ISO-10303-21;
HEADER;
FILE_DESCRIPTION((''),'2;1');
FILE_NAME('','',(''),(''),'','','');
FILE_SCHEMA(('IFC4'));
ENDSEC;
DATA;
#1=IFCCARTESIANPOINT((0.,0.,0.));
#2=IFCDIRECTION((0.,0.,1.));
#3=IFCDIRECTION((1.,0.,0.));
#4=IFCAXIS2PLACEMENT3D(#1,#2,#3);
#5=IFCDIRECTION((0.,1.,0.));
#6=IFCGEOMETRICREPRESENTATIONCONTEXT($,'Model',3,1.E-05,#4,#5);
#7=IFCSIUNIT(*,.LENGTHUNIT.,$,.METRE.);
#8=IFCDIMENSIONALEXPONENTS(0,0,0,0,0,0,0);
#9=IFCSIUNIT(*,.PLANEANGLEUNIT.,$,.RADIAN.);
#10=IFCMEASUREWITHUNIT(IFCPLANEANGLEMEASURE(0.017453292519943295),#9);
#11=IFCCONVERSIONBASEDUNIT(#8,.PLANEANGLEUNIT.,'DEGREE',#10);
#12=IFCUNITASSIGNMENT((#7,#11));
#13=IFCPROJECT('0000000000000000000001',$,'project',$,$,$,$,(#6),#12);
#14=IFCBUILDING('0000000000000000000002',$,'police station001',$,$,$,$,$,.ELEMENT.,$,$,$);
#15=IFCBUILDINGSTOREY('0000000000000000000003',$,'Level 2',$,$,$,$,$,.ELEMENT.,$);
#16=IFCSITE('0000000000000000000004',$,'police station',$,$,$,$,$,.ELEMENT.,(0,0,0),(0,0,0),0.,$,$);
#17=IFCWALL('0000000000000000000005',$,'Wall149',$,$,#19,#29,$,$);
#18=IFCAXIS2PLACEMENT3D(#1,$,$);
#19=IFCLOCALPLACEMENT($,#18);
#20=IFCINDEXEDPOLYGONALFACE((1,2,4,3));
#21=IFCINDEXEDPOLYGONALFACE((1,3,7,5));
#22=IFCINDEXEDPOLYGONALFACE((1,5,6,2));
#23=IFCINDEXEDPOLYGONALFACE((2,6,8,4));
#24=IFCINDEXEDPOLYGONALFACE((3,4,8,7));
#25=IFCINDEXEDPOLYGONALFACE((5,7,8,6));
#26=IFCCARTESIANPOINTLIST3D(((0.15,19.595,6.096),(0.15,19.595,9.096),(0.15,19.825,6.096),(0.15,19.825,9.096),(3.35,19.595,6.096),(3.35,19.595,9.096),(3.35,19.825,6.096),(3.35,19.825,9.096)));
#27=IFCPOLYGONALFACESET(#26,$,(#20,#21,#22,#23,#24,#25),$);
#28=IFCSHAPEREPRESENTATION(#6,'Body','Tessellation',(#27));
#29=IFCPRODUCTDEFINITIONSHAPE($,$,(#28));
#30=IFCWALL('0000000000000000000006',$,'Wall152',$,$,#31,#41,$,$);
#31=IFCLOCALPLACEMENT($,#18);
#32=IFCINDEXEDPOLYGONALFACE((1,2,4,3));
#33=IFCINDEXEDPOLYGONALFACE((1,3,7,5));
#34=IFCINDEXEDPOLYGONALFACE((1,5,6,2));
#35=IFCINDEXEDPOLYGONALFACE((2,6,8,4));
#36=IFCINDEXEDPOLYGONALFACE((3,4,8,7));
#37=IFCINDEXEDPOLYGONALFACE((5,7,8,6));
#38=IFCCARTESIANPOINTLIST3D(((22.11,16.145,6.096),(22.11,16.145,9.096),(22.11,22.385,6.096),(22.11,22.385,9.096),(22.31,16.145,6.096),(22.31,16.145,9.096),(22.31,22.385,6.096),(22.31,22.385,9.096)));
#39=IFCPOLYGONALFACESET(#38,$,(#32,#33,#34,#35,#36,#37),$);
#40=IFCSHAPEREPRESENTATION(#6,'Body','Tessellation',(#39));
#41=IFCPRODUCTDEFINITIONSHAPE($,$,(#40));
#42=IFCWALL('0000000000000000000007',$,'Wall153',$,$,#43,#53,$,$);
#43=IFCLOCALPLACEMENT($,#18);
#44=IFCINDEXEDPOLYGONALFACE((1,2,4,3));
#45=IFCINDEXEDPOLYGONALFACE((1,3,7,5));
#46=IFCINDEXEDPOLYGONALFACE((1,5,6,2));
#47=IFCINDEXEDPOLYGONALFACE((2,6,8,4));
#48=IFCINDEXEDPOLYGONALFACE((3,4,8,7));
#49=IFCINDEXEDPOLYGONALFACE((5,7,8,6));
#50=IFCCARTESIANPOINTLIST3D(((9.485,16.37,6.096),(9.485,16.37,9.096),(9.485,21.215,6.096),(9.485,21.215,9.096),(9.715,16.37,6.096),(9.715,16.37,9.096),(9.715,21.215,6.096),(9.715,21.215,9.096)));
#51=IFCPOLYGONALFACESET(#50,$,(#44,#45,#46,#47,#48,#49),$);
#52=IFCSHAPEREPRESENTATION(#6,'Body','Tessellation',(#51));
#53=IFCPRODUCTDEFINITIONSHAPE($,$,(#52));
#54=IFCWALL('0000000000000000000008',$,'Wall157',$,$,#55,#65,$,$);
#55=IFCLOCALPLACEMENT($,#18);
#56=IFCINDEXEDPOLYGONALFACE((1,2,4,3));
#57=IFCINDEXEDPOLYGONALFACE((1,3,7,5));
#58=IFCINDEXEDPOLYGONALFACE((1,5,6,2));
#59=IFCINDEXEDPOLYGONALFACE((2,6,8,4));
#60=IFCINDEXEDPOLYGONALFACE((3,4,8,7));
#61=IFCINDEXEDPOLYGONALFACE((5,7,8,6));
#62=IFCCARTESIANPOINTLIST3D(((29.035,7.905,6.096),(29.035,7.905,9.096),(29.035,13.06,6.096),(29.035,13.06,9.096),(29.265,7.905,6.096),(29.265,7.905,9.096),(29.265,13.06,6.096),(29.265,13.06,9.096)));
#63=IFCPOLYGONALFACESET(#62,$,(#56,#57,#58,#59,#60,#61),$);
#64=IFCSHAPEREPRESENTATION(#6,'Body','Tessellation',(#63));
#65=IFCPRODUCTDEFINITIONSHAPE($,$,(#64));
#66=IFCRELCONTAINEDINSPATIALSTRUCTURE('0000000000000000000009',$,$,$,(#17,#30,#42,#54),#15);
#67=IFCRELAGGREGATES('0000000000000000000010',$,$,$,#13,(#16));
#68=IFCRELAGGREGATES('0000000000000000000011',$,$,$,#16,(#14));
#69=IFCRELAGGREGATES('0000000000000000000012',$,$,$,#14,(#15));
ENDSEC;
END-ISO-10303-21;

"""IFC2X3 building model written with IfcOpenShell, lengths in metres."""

from ifc_helpers import new_model, entity, si_unit, converted_unit, direction, frame, frame_2d, origin_with_axes, place, context, project, spatial, rectangle, extrude, element, save


model = new_model("IFC2X3")

# Units and contexts
model_context = context("Model", 3, precision=1e-05, world=origin_with_axes(), true_north=direction((0.0, 1.0, 0.0)))
ifc_project = project(units=[si_unit("LENGTHUNIT", "METRE"), converted_unit("PLANEANGLEUNIT", "DEGREE", entity("IfcPlaneAngleMeasure", 0.017453292519943295), si_unit("PLANEANGLEUNIT", "RADIAN"), dimensions=[0, 0, 0, 0, 0, 0, 0])], contexts=[model_context])

# Site, building, storey
site = spatial("IfcSite", under=ifc_project, Name="police station", CompositionType="ELEMENT", RefLatitude=(0, 0, 0), RefLongitude=(0, 0, 0), RefElevation=0.0)
building = spatial("IfcBuilding", under=site, Name="police station001", CompositionType="ELEMENT")
storey = spatial("IfcBuildingStorey", under=building, Name="Level 2", CompositionType="ELEMENT")

# Shared definitions
placement = place(None, origin_with_axes())

# Walls
element("IfcWall", 1, at=placement, inside=storey, Name="Wall149", context=model_context, shape_type="SweptSolid", body=[
    extrude(rectangle(XDim=3.2, YDim=0.23, at=frame_2d((0.0, 0.0), x_axis=(1.0, 0.0, 0.0))), frame((1.75, 19.71, 6.096), z_axis=(0.0, 0.0, 1.0), x_axis=(1.0, 0.0, 0.0)), (0.0, 0.0, 1.0), 3.0),
])
element("IfcWall", 2, at=placement, inside=storey, Name="Wall152", context=model_context, shape_type="SweptSolid", body=[
    extrude(rectangle(XDim=6.24, YDim=0.2, at=frame_2d((0.0, 0.0), x_axis=(0.0, -1.0, 0.0))), frame((22.21, 19.265, 6.096), z_axis=(0.0, 0.0, 1.0), x_axis=(1.0, 0.0, 0.0)), (0.0, 0.0, 1.0), 3.0),
])
element("IfcWall", 3, at=placement, inside=storey, Name="Wall153", context=model_context, shape_type="SweptSolid", body=[
    extrude(rectangle(XDim=4.845, YDim=0.23, at=frame_2d((0.0, 0.0), x_axis=(0.0, -1.0, 0.0))), frame((9.6, 18.7925, 6.096), z_axis=(0.0, 0.0, 1.0), x_axis=(1.0, 0.0, 0.0)), (0.0, 0.0, 1.0), 3.0),
])
element("IfcWall", 4, at=placement, inside=storey, Name="Wall157", context=model_context, shape_type="SweptSolid", body=[
    extrude(rectangle(XDim=5.155, YDim=0.23, at=frame_2d((0.0, 0.0), x_axis=(0.0, -1.0, 0.0))), frame((29.15, 10.4825, 6.096), z_axis=(0.0, 0.0, 1.0), x_axis=(1.0, 0.0, 0.0)), (0.0, 0.0, 1.0), 3.0),
])

save(model, "model.ifc")
